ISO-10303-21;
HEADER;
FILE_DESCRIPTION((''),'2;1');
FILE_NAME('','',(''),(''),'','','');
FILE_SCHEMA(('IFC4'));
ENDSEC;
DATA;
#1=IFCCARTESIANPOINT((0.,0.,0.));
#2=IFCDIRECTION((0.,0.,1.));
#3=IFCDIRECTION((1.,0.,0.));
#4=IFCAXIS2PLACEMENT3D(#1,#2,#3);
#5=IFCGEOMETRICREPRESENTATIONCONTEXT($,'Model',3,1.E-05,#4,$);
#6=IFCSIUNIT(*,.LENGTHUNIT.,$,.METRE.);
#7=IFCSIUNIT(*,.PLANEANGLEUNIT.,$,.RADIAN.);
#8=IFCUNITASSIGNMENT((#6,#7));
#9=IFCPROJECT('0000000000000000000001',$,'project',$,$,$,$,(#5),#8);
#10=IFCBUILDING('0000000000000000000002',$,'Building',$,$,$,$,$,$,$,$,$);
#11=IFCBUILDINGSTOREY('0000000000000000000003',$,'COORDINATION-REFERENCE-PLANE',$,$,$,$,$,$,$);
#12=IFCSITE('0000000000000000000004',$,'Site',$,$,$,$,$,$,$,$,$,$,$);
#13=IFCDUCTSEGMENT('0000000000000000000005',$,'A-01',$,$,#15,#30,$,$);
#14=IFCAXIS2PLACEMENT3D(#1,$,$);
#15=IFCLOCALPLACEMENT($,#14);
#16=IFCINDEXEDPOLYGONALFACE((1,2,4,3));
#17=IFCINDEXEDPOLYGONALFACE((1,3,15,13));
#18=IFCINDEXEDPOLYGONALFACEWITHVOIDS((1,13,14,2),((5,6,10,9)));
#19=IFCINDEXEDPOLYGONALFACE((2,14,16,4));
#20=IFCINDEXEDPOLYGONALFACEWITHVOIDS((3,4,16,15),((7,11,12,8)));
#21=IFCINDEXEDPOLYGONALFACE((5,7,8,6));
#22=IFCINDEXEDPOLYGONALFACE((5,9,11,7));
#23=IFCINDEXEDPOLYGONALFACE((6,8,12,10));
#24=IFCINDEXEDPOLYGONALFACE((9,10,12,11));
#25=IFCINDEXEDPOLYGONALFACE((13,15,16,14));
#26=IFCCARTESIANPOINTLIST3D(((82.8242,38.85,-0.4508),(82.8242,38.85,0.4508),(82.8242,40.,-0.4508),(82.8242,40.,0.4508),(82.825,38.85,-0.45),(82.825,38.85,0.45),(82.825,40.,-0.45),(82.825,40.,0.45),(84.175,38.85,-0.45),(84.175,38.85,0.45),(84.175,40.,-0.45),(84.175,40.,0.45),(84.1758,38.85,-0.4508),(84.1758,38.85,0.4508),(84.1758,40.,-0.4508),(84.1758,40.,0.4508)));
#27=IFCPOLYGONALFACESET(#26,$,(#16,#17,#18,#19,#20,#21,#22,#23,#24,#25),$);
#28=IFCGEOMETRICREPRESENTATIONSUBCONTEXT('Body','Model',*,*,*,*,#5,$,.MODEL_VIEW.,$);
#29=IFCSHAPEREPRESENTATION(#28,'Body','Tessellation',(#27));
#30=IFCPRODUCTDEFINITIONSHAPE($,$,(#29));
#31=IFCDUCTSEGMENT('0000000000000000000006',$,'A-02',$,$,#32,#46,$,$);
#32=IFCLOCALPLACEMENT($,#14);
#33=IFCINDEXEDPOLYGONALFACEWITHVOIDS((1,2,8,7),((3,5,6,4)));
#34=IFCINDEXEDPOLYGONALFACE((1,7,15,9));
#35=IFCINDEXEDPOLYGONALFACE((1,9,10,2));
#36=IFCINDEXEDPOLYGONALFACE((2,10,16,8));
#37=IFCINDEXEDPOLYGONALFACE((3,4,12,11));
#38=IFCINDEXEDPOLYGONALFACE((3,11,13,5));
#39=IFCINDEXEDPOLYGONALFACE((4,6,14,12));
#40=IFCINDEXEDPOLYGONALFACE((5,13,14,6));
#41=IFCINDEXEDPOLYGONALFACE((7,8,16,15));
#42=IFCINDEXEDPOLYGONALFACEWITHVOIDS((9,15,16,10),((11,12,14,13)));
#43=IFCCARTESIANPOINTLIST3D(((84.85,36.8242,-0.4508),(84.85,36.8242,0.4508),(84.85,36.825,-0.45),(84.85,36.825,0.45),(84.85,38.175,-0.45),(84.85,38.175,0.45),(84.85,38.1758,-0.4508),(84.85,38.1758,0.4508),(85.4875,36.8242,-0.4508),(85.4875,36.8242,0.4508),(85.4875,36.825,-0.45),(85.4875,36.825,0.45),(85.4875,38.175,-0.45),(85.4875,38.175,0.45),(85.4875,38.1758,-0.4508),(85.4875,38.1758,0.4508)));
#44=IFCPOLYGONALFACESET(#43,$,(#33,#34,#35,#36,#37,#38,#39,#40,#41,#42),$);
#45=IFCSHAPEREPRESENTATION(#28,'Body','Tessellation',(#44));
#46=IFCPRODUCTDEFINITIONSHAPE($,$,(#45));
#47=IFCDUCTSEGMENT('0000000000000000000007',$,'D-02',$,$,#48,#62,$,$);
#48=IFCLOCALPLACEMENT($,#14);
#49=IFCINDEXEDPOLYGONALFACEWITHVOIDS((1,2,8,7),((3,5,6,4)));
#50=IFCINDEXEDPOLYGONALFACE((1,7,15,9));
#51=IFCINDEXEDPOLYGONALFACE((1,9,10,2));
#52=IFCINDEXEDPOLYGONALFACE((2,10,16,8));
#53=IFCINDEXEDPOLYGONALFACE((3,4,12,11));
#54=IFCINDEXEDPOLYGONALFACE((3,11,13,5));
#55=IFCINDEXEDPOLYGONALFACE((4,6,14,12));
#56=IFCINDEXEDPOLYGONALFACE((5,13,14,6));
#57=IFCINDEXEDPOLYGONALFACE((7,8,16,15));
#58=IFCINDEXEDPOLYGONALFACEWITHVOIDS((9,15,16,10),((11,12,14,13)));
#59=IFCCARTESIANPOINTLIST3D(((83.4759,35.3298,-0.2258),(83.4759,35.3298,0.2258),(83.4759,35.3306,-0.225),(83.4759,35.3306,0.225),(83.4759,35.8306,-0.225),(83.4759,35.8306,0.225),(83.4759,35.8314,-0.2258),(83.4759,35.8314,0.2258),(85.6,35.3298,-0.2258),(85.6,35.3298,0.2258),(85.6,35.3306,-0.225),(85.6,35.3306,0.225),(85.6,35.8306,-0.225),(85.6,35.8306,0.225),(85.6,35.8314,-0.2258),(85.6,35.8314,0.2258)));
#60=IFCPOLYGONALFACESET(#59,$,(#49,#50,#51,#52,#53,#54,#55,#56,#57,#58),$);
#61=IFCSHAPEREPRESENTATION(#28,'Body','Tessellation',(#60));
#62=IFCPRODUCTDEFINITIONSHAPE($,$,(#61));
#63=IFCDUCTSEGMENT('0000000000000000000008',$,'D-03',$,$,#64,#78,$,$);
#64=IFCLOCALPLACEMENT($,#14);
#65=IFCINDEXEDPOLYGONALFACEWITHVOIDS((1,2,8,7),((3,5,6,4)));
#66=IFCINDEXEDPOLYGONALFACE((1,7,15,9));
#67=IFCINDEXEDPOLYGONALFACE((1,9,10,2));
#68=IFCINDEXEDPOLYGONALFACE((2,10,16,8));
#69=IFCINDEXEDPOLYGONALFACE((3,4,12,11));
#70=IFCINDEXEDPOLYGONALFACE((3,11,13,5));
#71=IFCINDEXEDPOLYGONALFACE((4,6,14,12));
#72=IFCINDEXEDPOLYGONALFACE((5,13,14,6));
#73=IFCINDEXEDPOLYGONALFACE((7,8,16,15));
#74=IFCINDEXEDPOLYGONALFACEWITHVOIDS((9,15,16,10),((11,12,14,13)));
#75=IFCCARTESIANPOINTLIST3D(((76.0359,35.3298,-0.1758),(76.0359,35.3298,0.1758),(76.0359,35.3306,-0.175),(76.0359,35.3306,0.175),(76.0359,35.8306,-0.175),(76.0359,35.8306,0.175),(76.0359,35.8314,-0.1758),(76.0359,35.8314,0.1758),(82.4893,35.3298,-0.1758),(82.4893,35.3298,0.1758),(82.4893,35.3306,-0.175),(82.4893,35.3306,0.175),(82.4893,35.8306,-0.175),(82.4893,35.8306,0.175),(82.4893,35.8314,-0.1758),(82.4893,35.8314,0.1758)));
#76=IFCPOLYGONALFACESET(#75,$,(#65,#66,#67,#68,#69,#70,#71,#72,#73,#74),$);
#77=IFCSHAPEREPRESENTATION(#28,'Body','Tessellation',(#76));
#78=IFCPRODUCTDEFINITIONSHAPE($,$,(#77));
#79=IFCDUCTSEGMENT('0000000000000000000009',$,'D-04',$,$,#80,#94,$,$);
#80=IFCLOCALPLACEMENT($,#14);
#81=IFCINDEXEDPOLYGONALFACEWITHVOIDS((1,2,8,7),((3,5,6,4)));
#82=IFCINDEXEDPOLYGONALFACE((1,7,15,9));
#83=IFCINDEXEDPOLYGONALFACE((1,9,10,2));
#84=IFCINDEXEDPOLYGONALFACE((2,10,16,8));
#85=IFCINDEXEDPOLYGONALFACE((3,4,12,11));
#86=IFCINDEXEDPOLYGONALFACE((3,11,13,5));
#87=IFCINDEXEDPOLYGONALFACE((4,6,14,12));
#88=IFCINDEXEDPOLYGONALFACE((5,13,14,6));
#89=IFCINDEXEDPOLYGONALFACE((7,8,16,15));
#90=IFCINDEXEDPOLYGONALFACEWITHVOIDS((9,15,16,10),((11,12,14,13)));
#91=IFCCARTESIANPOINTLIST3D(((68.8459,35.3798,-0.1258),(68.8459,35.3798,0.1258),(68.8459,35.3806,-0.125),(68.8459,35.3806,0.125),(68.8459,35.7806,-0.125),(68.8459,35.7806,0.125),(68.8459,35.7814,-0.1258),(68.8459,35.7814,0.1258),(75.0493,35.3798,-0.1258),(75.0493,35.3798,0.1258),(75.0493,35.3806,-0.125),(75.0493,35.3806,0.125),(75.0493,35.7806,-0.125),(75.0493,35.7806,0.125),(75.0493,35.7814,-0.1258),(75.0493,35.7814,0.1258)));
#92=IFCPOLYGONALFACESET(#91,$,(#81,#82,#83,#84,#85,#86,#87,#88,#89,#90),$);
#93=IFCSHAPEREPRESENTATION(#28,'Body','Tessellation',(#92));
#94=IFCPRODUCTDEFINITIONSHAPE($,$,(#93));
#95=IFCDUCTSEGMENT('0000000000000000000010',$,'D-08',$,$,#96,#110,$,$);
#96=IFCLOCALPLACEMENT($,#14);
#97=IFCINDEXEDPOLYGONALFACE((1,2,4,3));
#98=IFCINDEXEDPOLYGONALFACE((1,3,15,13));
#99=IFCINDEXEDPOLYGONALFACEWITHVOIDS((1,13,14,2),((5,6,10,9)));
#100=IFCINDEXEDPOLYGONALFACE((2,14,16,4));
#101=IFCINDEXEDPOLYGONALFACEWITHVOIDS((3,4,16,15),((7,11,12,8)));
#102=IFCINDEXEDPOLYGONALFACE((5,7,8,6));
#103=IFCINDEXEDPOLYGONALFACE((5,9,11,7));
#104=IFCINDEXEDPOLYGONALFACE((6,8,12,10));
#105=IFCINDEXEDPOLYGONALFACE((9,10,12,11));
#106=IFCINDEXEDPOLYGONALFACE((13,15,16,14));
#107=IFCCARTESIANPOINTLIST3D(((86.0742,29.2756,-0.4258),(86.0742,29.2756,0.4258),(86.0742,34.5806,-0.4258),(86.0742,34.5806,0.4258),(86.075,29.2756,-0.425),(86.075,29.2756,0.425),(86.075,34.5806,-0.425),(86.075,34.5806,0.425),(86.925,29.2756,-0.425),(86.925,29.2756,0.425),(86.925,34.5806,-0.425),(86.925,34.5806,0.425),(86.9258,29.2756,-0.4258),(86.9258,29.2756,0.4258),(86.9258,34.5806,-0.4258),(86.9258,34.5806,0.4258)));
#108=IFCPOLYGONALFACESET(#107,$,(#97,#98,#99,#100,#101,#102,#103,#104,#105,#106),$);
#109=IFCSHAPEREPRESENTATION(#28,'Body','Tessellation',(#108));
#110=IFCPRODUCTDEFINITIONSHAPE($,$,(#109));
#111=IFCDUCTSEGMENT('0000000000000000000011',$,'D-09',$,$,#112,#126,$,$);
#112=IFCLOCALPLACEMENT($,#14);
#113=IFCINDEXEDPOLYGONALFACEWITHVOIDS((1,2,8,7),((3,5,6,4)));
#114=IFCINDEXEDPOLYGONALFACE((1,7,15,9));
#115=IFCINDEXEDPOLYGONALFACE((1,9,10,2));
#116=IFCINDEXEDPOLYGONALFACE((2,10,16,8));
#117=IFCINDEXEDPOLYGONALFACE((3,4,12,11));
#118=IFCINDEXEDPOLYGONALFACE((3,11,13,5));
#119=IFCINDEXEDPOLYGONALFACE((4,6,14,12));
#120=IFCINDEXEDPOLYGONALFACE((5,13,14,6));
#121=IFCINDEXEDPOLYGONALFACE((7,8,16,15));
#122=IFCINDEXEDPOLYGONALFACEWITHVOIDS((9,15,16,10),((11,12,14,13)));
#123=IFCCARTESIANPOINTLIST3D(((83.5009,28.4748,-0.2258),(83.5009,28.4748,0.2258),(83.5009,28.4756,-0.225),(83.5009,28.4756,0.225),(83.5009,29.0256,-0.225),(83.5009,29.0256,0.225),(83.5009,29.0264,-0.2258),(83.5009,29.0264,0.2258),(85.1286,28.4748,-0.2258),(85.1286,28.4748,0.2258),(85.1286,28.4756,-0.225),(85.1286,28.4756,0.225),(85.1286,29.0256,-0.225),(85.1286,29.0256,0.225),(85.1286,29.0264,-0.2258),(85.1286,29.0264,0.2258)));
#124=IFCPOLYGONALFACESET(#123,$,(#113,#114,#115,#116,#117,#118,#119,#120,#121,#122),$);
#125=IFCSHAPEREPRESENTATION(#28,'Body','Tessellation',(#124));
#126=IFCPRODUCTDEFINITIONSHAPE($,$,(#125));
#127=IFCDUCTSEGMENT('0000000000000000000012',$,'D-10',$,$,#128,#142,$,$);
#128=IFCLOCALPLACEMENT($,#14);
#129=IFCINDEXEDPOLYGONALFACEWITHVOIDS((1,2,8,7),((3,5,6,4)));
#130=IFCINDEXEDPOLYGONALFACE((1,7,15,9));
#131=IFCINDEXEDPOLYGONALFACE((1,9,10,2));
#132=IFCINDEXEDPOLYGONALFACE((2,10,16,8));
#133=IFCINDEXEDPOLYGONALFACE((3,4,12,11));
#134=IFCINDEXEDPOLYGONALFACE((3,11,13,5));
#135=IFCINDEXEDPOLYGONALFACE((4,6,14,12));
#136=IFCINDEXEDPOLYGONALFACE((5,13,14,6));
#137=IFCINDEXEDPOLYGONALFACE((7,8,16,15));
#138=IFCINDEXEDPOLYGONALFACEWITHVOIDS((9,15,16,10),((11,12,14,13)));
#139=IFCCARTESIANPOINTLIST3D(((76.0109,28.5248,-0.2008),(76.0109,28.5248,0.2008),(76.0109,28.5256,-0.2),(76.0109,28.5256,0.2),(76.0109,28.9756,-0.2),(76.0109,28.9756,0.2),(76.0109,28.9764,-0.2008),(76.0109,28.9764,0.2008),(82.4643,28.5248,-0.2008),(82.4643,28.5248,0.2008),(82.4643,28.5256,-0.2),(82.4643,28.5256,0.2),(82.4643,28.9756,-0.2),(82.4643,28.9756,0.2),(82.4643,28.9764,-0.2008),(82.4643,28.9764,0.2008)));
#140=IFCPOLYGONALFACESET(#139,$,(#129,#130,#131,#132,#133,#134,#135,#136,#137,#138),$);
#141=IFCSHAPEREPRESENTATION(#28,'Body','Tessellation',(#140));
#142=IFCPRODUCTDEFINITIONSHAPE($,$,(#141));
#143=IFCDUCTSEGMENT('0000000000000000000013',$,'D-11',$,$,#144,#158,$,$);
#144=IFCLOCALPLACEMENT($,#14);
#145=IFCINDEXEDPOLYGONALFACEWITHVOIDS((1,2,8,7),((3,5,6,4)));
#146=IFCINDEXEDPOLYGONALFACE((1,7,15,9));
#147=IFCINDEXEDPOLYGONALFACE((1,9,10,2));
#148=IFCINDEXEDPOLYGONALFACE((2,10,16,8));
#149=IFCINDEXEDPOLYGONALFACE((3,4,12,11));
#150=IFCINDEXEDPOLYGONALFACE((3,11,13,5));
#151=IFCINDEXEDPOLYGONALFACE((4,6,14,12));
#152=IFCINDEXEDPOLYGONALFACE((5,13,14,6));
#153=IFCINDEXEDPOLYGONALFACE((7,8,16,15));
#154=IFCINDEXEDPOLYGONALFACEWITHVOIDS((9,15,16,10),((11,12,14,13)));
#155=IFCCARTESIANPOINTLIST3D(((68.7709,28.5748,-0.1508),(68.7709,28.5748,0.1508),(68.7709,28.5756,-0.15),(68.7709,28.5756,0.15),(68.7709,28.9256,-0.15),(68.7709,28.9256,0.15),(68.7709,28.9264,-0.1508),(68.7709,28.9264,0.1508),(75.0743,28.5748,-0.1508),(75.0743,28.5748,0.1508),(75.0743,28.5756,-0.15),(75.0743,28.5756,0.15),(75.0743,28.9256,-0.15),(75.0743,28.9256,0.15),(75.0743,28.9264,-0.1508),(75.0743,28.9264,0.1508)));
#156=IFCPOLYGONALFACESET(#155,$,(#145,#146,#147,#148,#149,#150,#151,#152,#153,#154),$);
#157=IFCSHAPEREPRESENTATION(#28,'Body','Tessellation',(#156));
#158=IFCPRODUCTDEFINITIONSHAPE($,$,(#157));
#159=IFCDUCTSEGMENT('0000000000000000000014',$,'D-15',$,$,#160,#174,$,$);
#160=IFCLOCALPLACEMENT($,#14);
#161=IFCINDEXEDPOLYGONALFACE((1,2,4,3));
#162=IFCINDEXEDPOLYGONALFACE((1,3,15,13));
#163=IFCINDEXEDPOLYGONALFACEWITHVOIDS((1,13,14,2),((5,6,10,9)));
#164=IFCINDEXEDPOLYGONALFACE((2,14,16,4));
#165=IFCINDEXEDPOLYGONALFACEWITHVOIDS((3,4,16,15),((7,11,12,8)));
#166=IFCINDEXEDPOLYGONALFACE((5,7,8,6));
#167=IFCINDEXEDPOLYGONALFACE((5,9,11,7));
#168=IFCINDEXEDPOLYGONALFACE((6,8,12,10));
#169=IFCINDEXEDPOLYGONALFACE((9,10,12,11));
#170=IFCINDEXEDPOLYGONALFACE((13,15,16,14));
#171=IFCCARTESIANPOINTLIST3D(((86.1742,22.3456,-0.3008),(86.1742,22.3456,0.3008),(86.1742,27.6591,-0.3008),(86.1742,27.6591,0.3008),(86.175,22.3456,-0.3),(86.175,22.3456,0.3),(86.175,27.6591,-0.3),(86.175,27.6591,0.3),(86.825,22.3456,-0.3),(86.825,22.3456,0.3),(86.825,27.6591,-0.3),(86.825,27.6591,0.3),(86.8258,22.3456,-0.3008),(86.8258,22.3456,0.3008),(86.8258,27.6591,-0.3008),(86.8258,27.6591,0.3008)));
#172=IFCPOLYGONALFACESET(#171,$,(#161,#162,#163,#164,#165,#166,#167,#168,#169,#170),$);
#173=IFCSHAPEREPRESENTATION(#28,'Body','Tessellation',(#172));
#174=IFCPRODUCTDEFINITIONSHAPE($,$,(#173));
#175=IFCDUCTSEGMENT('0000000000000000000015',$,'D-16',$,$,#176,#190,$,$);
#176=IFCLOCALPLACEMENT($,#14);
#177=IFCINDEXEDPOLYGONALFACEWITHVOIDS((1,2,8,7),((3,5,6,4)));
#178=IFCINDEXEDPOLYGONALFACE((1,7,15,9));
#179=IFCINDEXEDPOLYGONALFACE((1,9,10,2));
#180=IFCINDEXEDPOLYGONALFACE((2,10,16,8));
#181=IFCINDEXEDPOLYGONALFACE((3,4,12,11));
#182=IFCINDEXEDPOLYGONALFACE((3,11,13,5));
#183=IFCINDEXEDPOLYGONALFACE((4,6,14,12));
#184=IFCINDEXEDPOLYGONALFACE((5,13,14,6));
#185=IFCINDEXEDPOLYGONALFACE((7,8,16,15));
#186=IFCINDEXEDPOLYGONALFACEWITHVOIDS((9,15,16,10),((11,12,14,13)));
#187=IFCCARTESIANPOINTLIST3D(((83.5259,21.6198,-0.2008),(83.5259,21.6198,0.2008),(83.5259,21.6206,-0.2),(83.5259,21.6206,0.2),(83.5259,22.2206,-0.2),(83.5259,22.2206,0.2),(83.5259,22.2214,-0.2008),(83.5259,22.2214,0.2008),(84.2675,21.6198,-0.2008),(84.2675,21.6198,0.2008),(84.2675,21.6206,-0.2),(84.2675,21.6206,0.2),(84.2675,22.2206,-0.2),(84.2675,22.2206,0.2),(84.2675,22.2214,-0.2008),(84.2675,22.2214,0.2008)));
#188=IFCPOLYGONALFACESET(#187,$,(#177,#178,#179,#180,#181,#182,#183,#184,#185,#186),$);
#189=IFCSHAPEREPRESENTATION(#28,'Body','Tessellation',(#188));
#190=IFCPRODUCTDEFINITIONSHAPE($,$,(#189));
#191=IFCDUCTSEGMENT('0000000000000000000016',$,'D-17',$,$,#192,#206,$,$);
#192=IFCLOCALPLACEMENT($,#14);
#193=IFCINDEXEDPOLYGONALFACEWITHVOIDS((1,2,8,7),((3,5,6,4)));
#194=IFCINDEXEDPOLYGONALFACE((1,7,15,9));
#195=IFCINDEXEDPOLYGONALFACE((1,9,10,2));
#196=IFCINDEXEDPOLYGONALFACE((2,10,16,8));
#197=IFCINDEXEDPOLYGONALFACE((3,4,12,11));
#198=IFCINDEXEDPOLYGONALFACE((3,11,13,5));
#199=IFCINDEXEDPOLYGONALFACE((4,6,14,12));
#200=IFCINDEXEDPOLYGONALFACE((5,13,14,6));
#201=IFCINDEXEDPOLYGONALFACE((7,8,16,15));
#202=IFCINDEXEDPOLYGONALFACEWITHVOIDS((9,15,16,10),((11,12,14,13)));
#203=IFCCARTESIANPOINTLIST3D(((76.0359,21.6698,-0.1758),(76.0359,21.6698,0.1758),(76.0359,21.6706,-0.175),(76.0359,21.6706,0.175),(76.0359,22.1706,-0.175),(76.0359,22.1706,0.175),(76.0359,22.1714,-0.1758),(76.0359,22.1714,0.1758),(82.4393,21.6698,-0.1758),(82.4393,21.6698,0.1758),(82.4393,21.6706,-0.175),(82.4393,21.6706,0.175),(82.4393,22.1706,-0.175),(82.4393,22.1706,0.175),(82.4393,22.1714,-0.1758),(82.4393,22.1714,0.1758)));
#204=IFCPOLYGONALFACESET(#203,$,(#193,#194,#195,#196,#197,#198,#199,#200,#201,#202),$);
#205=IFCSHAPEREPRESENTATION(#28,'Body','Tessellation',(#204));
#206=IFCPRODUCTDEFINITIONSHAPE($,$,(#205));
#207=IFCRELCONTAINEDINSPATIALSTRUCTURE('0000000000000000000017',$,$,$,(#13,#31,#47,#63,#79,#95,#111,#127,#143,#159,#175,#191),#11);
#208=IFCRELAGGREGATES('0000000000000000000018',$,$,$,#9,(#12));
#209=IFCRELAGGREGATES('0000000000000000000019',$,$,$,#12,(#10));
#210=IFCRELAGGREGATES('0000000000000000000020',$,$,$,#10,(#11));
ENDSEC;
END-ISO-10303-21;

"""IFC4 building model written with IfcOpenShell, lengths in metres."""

from ifc_helpers import new_model, si_unit, frame, origin, origin_with_axes, place, context, subcontext, project, spatial, hollow_rectangle, extrude, element, save


model = new_model("IFC4")

# Units and contexts
model_context = context("Model", 3, precision=1e-05, world=origin_with_axes())
body_context = subcontext(model_context, "Body", "Model", "MODEL_VIEW")
ifc_project = project(units=[si_unit("LENGTHUNIT", "METRE"), si_unit("PLANEANGLEUNIT", "RADIAN")], contexts=[model_context])

# Site, building, storey
site = spatial("IfcSite", under=ifc_project, Name="Site")
building = spatial("IfcBuilding", under=site, Name="Building")
storey = spatial("IfcBuildingStorey", under=building, Name="COORDINATION-REFERENCE-PLANE")

# Duct segments
duct_segment_1_placement = place(None, frame((83.5, 38.85, 0.0), z_axis=(0.0, 1.0, 0.0), x_axis=(1.0, 0.0, 0.0)))
element("IfcDuctSegment", 1, at=duct_segment_1_placement, inside=storey, Name="A-01", context=body_context, shape_type="SweptSolid", body=[
    extrude(hollow_rectangle(XDim=1.3516, YDim=0.9016, WallThickness=0.0008), origin(), (0.0, 0.0, 1.0), 1.15),
])
duct_segment_2_placement = place(None, frame((84.85, 37.5, 0.0), z_axis=(1.0, 0.0, 0.0), x_axis=(0.0, 1.0, 0.0)))
element("IfcDuctSegment", 2, at=duct_segment_2_placement, inside=storey, Name="A-02", context=body_context, shape_type="SweptSolid", body=[
    extrude(hollow_rectangle(XDim=1.3516, YDim=0.9016, WallThickness=0.0008), origin(), (0.0, 0.0, 1.0), 0.6375),
])
duct_segment_3_placement = place(None, frame((83.4759, 35.5806, 0.0), z_axis=(1.0, 0.0, 0.0), x_axis=(0.0, 1.0, 0.0)))
element("IfcDuctSegment", 3, at=duct_segment_3_placement, inside=storey, Name="D-02", context=body_context, shape_type="SweptSolid", body=[
    extrude(hollow_rectangle(XDim=0.5016, YDim=0.4516, WallThickness=0.0008), origin(), (0.0, 0.0, 1.0), 2.1241),
])
duct_segment_4_placement = place(None, frame((76.0359, 35.5806, 0.0), z_axis=(1.0, 0.0, 0.0), x_axis=(0.0, 1.0, 0.0)))
element("IfcDuctSegment", 4, at=duct_segment_4_placement, inside=storey, Name="D-03", context=body_context, shape_type="SweptSolid", body=[
    extrude(hollow_rectangle(XDim=0.5016, YDim=0.3516, WallThickness=0.0008), origin(), (0.0, 0.0, 1.0), 6.4534),
])
duct_segment_5_placement = place(None, frame((68.8459, 35.5806, 0.0), z_axis=(1.0, 0.0, 0.0), x_axis=(0.0, 1.0, 0.0)))
element("IfcDuctSegment", 5, at=duct_segment_5_placement, inside=storey, Name="D-04", context=body_context, shape_type="SweptSolid", body=[
    extrude(hollow_rectangle(XDim=0.4016, YDim=0.2516, WallThickness=0.0008), origin(), (0.0, 0.0, 1.0), 6.2034),
])
duct_segment_6_placement = place(None, frame((86.5, 29.2756, 0.0), z_axis=(0.0, 1.0, 0.0), x_axis=(1.0, 0.0, 0.0)))
element("IfcDuctSegment", 6, at=duct_segment_6_placement, inside=storey, Name="D-08", context=body_context, shape_type="SweptSolid", body=[
    extrude(hollow_rectangle(XDim=0.8516, YDim=0.8516, WallThickness=0.0008), origin(), (0.0, 0.0, 1.0), 5.305),
])
duct_segment_7_placement = place(None, frame((83.5009, 28.7506, 0.0), z_axis=(1.0, 0.0, 0.0), x_axis=(0.0, 1.0, 0.0)))
element("IfcDuctSegment", 7, at=duct_segment_7_placement, inside=storey, Name="D-09", context=body_context, shape_type="SweptSolid", body=[
    extrude(hollow_rectangle(XDim=0.5516, YDim=0.4516, WallThickness=0.0008), origin(), (0.0, 0.0, 1.0), 1.6277),
])
duct_segment_8_placement = place(None, frame((76.0109, 28.7506, 0.0), z_axis=(1.0, 0.0, 0.0), x_axis=(0.0, 1.0, 0.0)))
element("IfcDuctSegment", 8, at=duct_segment_8_placement, inside=storey, Name="D-10", context=body_context, shape_type="SweptSolid", body=[
    extrude(hollow_rectangle(XDim=0.4516, YDim=0.4016, WallThickness=0.0008), origin(), (0.0, 0.0, 1.0), 6.4534),
])
duct_segment_9_placement = place(None, frame((68.7709, 28.7506, 0.0), z_axis=(1.0, 0.0, 0.0), x_axis=(0.0, 1.0, 0.0)))
element("IfcDuctSegment", 9, at=duct_segment_9_placement, inside=storey, Name="D-11", context=body_context, shape_type="SweptSolid", body=[
    extrude(hollow_rectangle(XDim=0.3516, YDim=0.3016, WallThickness=0.0008), origin(), (0.0, 0.0, 1.0), 6.3034),
])
duct_segment_10_placement = place(None, frame((86.5, 22.3456, 0.0), z_axis=(0.0, 1.0, 0.0), x_axis=(1.0, 0.0, 0.0)))
element("IfcDuctSegment", 10, at=duct_segment_10_placement, inside=storey, Name="D-15", context=body_context, shape_type="SweptSolid", body=[
    extrude(hollow_rectangle(XDim=0.6516, YDim=0.6016, WallThickness=0.0008), origin(), (0.0, 0.0, 1.0), 5.3135),
])
duct_segment_11_placement = place(None, frame((83.5259, 21.9206, 0.0), z_axis=(1.0, 0.0, 0.0), x_axis=(0.0, 1.0, 0.0)))
element("IfcDuctSegment", 11, at=duct_segment_11_placement, inside=storey, Name="D-16", context=body_context, shape_type="SweptSolid", body=[
    extrude(hollow_rectangle(XDim=0.6016, YDim=0.4016, WallThickness=0.0008), origin(), (0.0, 0.0, 1.0), 0.7416),
])
duct_segment_12_placement = place(None, frame((76.0359, 21.9206, 0.0), z_axis=(1.0, 0.0, 0.0), x_axis=(0.0, 1.0, 0.0)))
element("IfcDuctSegment", 12, at=duct_segment_12_placement, inside=storey, Name="D-17", context=body_context, shape_type="SweptSolid", body=[
    extrude(hollow_rectangle(XDim=0.5016, YDim=0.3516, WallThickness=0.0008), origin(), (0.0, 0.0, 1.0), 6.4034),
])

save(model, "model.ifc")
